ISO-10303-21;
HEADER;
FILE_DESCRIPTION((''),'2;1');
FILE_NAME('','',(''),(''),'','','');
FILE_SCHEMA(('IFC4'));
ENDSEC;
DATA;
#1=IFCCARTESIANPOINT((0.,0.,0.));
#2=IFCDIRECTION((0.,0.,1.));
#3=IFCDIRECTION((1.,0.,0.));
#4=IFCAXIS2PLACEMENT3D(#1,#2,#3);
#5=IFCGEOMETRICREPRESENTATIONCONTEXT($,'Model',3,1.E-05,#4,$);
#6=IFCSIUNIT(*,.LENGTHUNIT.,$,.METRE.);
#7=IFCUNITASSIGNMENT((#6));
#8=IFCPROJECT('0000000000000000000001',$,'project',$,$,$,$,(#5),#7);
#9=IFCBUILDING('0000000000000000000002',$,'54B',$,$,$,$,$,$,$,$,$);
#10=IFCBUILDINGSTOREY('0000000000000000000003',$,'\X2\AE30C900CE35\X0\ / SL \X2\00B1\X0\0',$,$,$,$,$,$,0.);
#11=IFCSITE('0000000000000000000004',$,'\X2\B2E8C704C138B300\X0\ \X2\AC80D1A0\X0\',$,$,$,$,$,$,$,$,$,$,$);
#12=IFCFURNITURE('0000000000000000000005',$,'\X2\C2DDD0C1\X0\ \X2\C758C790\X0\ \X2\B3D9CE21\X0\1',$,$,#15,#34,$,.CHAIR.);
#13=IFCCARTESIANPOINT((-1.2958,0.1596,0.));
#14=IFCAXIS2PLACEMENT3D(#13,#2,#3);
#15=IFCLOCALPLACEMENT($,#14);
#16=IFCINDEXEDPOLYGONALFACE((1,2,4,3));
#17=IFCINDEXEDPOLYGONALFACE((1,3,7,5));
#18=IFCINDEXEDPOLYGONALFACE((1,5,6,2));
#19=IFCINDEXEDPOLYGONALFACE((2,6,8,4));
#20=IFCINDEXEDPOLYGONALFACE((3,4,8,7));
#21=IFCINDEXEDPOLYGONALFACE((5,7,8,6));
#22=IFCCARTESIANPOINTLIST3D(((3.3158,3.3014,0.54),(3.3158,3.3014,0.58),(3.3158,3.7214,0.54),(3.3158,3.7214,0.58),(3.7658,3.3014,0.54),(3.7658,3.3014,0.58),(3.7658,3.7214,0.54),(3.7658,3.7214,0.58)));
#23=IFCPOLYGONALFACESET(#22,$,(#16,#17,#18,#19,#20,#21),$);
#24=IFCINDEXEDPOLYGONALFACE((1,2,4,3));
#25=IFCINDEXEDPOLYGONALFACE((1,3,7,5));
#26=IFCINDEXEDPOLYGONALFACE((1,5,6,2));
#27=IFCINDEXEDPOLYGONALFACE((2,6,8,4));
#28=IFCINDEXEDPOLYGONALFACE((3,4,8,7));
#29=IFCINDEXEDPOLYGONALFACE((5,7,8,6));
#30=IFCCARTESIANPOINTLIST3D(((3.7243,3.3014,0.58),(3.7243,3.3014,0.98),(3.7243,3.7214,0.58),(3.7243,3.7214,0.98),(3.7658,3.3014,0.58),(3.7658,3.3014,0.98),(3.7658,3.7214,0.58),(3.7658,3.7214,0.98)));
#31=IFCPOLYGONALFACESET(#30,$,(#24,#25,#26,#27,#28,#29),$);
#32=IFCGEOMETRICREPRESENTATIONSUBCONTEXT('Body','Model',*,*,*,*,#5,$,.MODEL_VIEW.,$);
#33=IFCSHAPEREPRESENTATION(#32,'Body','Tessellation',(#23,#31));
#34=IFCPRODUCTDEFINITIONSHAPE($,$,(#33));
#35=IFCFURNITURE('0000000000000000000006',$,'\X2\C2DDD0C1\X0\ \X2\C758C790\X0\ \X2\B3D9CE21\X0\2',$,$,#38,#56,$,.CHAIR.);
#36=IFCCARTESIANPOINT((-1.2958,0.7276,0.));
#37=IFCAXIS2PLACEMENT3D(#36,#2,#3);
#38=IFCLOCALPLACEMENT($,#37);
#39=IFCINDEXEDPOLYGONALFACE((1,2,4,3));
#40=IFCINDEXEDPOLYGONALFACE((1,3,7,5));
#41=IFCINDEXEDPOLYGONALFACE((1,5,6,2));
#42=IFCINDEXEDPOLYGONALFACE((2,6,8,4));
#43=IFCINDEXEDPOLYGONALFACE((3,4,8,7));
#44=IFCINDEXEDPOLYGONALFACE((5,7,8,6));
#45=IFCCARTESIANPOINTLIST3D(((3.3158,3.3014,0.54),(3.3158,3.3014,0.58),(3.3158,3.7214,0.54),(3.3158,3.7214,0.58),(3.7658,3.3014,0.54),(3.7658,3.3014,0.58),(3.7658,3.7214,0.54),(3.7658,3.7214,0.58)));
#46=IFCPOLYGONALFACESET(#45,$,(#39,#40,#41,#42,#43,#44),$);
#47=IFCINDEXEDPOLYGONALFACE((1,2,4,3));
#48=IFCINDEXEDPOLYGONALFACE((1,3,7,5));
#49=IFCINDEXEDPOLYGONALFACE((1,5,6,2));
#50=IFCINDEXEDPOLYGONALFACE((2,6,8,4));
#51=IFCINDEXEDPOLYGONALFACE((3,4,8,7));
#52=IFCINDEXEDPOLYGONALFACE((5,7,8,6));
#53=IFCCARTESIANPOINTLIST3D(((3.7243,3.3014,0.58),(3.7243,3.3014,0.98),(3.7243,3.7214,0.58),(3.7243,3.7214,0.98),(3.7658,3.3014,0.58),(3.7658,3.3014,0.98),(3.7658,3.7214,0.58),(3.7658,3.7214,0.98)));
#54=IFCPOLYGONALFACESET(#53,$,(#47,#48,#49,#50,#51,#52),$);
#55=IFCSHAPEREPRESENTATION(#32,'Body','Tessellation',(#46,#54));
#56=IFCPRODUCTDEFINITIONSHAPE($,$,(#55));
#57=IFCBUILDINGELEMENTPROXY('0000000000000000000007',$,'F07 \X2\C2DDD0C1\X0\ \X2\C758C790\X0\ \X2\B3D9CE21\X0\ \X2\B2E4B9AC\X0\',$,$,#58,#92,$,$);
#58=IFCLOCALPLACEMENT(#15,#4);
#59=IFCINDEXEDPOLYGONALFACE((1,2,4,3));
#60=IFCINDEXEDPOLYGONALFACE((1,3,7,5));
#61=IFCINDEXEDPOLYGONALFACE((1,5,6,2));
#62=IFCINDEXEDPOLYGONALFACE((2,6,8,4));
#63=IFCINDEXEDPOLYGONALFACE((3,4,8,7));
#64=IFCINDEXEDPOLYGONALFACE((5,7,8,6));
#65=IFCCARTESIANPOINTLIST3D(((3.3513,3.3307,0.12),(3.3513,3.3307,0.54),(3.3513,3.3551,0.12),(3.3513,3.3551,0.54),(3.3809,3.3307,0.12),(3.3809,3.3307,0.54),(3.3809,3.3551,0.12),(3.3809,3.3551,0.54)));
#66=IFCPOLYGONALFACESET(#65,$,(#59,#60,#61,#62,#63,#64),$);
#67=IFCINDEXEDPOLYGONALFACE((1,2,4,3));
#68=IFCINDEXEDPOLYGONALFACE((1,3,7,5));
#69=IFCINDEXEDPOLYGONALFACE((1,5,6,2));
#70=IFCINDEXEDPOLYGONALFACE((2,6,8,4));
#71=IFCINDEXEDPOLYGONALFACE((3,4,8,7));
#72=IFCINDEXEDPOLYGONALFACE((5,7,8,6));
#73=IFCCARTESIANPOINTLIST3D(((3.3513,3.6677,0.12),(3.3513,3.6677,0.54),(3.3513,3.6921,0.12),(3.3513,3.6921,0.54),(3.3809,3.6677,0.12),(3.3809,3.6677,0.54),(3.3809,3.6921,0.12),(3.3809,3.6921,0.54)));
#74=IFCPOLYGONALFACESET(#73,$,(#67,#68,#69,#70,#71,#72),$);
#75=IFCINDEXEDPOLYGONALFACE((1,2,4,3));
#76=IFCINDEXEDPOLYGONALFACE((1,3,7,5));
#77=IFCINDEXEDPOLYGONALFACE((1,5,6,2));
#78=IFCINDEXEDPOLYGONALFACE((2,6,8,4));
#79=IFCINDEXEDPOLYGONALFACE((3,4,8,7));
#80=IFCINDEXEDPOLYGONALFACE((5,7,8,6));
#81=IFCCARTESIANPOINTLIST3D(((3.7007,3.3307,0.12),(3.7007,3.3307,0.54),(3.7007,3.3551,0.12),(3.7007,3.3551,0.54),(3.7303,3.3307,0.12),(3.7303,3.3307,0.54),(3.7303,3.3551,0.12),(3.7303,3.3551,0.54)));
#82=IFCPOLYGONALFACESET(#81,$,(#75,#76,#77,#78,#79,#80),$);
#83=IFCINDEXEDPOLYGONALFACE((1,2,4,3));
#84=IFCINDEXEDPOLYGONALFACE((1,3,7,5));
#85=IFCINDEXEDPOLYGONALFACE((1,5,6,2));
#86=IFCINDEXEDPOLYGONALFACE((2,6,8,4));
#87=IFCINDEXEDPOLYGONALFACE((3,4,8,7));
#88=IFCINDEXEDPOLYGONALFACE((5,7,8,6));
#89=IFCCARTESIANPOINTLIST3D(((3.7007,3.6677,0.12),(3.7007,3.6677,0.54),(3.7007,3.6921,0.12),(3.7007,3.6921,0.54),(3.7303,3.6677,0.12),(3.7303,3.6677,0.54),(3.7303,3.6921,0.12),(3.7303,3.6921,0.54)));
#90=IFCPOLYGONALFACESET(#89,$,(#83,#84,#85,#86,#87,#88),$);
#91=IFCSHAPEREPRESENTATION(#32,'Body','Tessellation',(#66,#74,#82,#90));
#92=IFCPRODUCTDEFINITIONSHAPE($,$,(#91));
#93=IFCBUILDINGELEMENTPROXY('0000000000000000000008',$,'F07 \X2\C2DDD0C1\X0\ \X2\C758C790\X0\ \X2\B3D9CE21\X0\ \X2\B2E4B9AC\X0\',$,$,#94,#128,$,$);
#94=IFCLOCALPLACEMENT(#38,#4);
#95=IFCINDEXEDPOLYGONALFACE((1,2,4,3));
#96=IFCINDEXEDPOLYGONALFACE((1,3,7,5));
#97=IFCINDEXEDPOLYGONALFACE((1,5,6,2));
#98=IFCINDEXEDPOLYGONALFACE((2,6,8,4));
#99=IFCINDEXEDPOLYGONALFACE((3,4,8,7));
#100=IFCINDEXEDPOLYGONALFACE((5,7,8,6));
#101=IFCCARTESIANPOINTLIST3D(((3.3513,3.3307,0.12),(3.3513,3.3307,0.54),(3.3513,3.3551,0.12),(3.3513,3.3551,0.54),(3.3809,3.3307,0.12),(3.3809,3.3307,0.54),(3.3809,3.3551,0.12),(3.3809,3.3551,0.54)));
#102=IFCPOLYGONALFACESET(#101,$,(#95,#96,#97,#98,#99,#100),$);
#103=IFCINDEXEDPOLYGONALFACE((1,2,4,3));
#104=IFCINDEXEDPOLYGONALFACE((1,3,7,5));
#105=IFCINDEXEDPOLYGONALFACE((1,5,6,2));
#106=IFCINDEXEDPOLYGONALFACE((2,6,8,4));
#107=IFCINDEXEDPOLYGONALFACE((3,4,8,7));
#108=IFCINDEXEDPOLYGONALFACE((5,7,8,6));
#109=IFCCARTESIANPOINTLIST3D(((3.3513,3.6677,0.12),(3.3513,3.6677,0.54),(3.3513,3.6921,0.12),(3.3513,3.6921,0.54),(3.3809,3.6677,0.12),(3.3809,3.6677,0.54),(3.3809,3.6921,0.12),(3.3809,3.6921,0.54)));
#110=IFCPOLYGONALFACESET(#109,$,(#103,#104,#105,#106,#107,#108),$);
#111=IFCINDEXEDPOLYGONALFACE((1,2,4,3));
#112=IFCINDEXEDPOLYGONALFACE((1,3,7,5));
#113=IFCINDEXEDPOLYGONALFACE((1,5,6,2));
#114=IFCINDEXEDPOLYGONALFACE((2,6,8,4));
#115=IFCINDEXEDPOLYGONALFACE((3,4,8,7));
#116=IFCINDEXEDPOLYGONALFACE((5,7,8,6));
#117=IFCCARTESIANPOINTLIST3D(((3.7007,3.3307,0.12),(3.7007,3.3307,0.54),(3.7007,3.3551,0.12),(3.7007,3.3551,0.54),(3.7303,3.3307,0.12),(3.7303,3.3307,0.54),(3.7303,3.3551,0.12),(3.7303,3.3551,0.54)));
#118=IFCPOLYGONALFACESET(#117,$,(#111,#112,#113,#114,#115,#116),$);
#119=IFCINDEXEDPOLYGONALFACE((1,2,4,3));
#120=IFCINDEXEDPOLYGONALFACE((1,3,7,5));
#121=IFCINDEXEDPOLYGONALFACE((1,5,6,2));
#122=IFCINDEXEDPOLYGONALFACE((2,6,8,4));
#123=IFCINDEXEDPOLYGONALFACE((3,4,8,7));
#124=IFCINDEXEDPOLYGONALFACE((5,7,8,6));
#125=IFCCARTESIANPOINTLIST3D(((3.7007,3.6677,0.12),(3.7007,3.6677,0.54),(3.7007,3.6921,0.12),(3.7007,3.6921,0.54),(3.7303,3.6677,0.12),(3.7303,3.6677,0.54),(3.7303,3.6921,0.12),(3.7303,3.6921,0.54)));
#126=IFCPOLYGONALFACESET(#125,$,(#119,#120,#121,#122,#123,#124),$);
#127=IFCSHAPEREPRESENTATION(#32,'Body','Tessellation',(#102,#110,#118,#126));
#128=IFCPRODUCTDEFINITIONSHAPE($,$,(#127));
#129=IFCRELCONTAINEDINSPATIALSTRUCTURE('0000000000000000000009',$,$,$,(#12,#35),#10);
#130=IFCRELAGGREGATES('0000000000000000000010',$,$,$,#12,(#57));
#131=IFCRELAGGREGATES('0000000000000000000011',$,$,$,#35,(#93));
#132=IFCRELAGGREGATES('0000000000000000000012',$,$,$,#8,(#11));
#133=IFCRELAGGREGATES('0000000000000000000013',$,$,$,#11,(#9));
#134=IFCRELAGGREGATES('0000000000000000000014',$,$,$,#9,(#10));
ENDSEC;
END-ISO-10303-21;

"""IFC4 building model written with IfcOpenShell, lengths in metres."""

from ifc_helpers import new_model, si_unit, frame, origin_with_axes, place, context, subcontext, project, spatial, polyline, outline, extrude, element, aggregate, save


model = new_model("IFC4")

# Units and contexts
model_context = context("Model", 3, precision=1e-05, world=origin_with_axes())
body_context = subcontext(model_context, "Body", "Model", "MODEL_VIEW")
ifc_project = project(units=[si_unit("LENGTHUNIT", "METRE")], contexts=[model_context])

# Site, building, storey
site = spatial("IfcSite", under=ifc_project, Name="단위세대 검토")
building = spatial("IfcBuilding", under=site, Name="54B")
storey = spatial("IfcBuildingStorey", under=building, Name="기준층 / SL ±0", Elevation=0.0)

# Furniture
furniture_1_placement = place(None, frame((-1.2958, 0.1596, 0.0), z_axis=(0.0, 0.0, 1.0), x_axis=(1.0, 0.0, 0.0)))
furniture_1 = element("IfcFurniture", 1, at=furniture_1_placement, inside=storey, Name="식탁 의자 동측1", PredefinedType="CHAIR", context=body_context, shape_type="SweptSolid", body=[
    extrude(outline(polyline([(3.7658, 3.3014), (3.7658, 3.7214), (3.3158, 3.7214), (3.3158, 3.3014), (3.7658, 3.3014)])), frame((0.0, 0.0, 0.54)), (0.0, 0.0, 1.0), 0.04),
    extrude(outline(polyline([(3.7658, 3.3014), (3.7658, 3.7214), (3.7243, 3.7214), (3.7243, 3.3014), (3.7658, 3.3014)])), frame((0.0, 0.0, 0.58)), (0.0, 0.0, 1.0), 0.4),
])
furniture_2_placement = place(None, frame((-1.2958, 0.7276, 0.0), z_axis=(0.0, 0.0, 1.0), x_axis=(1.0, 0.0, 0.0)))
furniture_2 = element("IfcFurniture", 2, at=furniture_2_placement, inside=storey, Name="식탁 의자 동측2", PredefinedType="CHAIR", context=body_context, shape_type="SweptSolid", body=[
    extrude(outline(polyline([(3.7658, 3.3014), (3.7658, 3.7214), (3.3158, 3.7214), (3.3158, 3.3014), (3.7658, 3.3014)])), frame((0.0, 0.0, 0.54)), (0.0, 0.0, 1.0), 0.04),
    extrude(outline(polyline([(3.7658, 3.3014), (3.7658, 3.7214), (3.7243, 3.7214), (3.7243, 3.3014), (3.7658, 3.3014)])), frame((0.0, 0.0, 0.58)), (0.0, 0.0, 1.0), 0.4),
])

# Building element proxies
proxy_1_placement = place(furniture_1_placement, origin_with_axes())
proxy_1 = element("IfcBuildingElementProxy", 3, at=proxy_1_placement, Name="F07 식탁 의자 동측 다리", context=body_context, shape_type="SweptSolid", body=[
    extrude(outline(polyline([(3.3809, 3.3307), (3.3809, 3.3551), (3.3513, 3.3551), (3.3513, 3.3307), (3.3809, 3.3307)])), frame((0.0, 0.0, 0.12)), (0.0, 0.0, 1.0), 0.42),
    extrude(outline(polyline([(3.3809, 3.6677), (3.3809, 3.6921), (3.3513, 3.6921), (3.3513, 3.6677), (3.3809, 3.6677)])), frame((0.0, 0.0, 0.12)), (0.0, 0.0, 1.0), 0.42),
    extrude(outline(polyline([(3.7303, 3.3307), (3.7303, 3.3551), (3.7007, 3.3551), (3.7007, 3.3307), (3.7303, 3.3307)])), frame((0.0, 0.0, 0.12)), (0.0, 0.0, 1.0), 0.42),
    extrude(outline(polyline([(3.7303, 3.6677), (3.7303, 3.6921), (3.7007, 3.6921), (3.7007, 3.6677), (3.7303, 3.6677)])), frame((0.0, 0.0, 0.12)), (0.0, 0.0, 1.0), 0.42),
])
aggregate(furniture_1, [proxy_1])
proxy_2_placement = place(furniture_2_placement, origin_with_axes())
proxy_2 = element("IfcBuildingElementProxy", 4, at=proxy_2_placement, Name="F07 식탁 의자 동측 다리", context=body_context, shape_type="SweptSolid", body=[
    extrude(outline(polyline([(3.3809, 3.3307), (3.3809, 3.3551), (3.3513, 3.3551), (3.3513, 3.3307), (3.3809, 3.3307)])), frame((0.0, 0.0, 0.12)), (0.0, 0.0, 1.0), 0.42),
    extrude(outline(polyline([(3.3809, 3.6677), (3.3809, 3.6921), (3.3513, 3.6921), (3.3513, 3.6677), (3.3809, 3.6677)])), frame((0.0, 0.0, 0.12)), (0.0, 0.0, 1.0), 0.42),
    extrude(outline(polyline([(3.7303, 3.3307), (3.7303, 3.3551), (3.7007, 3.3551), (3.7007, 3.3307), (3.7303, 3.3307)])), frame((0.0, 0.0, 0.12)), (0.0, 0.0, 1.0), 0.42),
    extrude(outline(polyline([(3.7303, 3.6677), (3.7303, 3.6921), (3.7007, 3.6921), (3.7007, 3.6677), (3.7303, 3.6677)])), frame((0.0, 0.0, 0.12)), (0.0, 0.0, 1.0), 0.42),
])
aggregate(furniture_2, [proxy_2])

save(model, "model.ifc")
